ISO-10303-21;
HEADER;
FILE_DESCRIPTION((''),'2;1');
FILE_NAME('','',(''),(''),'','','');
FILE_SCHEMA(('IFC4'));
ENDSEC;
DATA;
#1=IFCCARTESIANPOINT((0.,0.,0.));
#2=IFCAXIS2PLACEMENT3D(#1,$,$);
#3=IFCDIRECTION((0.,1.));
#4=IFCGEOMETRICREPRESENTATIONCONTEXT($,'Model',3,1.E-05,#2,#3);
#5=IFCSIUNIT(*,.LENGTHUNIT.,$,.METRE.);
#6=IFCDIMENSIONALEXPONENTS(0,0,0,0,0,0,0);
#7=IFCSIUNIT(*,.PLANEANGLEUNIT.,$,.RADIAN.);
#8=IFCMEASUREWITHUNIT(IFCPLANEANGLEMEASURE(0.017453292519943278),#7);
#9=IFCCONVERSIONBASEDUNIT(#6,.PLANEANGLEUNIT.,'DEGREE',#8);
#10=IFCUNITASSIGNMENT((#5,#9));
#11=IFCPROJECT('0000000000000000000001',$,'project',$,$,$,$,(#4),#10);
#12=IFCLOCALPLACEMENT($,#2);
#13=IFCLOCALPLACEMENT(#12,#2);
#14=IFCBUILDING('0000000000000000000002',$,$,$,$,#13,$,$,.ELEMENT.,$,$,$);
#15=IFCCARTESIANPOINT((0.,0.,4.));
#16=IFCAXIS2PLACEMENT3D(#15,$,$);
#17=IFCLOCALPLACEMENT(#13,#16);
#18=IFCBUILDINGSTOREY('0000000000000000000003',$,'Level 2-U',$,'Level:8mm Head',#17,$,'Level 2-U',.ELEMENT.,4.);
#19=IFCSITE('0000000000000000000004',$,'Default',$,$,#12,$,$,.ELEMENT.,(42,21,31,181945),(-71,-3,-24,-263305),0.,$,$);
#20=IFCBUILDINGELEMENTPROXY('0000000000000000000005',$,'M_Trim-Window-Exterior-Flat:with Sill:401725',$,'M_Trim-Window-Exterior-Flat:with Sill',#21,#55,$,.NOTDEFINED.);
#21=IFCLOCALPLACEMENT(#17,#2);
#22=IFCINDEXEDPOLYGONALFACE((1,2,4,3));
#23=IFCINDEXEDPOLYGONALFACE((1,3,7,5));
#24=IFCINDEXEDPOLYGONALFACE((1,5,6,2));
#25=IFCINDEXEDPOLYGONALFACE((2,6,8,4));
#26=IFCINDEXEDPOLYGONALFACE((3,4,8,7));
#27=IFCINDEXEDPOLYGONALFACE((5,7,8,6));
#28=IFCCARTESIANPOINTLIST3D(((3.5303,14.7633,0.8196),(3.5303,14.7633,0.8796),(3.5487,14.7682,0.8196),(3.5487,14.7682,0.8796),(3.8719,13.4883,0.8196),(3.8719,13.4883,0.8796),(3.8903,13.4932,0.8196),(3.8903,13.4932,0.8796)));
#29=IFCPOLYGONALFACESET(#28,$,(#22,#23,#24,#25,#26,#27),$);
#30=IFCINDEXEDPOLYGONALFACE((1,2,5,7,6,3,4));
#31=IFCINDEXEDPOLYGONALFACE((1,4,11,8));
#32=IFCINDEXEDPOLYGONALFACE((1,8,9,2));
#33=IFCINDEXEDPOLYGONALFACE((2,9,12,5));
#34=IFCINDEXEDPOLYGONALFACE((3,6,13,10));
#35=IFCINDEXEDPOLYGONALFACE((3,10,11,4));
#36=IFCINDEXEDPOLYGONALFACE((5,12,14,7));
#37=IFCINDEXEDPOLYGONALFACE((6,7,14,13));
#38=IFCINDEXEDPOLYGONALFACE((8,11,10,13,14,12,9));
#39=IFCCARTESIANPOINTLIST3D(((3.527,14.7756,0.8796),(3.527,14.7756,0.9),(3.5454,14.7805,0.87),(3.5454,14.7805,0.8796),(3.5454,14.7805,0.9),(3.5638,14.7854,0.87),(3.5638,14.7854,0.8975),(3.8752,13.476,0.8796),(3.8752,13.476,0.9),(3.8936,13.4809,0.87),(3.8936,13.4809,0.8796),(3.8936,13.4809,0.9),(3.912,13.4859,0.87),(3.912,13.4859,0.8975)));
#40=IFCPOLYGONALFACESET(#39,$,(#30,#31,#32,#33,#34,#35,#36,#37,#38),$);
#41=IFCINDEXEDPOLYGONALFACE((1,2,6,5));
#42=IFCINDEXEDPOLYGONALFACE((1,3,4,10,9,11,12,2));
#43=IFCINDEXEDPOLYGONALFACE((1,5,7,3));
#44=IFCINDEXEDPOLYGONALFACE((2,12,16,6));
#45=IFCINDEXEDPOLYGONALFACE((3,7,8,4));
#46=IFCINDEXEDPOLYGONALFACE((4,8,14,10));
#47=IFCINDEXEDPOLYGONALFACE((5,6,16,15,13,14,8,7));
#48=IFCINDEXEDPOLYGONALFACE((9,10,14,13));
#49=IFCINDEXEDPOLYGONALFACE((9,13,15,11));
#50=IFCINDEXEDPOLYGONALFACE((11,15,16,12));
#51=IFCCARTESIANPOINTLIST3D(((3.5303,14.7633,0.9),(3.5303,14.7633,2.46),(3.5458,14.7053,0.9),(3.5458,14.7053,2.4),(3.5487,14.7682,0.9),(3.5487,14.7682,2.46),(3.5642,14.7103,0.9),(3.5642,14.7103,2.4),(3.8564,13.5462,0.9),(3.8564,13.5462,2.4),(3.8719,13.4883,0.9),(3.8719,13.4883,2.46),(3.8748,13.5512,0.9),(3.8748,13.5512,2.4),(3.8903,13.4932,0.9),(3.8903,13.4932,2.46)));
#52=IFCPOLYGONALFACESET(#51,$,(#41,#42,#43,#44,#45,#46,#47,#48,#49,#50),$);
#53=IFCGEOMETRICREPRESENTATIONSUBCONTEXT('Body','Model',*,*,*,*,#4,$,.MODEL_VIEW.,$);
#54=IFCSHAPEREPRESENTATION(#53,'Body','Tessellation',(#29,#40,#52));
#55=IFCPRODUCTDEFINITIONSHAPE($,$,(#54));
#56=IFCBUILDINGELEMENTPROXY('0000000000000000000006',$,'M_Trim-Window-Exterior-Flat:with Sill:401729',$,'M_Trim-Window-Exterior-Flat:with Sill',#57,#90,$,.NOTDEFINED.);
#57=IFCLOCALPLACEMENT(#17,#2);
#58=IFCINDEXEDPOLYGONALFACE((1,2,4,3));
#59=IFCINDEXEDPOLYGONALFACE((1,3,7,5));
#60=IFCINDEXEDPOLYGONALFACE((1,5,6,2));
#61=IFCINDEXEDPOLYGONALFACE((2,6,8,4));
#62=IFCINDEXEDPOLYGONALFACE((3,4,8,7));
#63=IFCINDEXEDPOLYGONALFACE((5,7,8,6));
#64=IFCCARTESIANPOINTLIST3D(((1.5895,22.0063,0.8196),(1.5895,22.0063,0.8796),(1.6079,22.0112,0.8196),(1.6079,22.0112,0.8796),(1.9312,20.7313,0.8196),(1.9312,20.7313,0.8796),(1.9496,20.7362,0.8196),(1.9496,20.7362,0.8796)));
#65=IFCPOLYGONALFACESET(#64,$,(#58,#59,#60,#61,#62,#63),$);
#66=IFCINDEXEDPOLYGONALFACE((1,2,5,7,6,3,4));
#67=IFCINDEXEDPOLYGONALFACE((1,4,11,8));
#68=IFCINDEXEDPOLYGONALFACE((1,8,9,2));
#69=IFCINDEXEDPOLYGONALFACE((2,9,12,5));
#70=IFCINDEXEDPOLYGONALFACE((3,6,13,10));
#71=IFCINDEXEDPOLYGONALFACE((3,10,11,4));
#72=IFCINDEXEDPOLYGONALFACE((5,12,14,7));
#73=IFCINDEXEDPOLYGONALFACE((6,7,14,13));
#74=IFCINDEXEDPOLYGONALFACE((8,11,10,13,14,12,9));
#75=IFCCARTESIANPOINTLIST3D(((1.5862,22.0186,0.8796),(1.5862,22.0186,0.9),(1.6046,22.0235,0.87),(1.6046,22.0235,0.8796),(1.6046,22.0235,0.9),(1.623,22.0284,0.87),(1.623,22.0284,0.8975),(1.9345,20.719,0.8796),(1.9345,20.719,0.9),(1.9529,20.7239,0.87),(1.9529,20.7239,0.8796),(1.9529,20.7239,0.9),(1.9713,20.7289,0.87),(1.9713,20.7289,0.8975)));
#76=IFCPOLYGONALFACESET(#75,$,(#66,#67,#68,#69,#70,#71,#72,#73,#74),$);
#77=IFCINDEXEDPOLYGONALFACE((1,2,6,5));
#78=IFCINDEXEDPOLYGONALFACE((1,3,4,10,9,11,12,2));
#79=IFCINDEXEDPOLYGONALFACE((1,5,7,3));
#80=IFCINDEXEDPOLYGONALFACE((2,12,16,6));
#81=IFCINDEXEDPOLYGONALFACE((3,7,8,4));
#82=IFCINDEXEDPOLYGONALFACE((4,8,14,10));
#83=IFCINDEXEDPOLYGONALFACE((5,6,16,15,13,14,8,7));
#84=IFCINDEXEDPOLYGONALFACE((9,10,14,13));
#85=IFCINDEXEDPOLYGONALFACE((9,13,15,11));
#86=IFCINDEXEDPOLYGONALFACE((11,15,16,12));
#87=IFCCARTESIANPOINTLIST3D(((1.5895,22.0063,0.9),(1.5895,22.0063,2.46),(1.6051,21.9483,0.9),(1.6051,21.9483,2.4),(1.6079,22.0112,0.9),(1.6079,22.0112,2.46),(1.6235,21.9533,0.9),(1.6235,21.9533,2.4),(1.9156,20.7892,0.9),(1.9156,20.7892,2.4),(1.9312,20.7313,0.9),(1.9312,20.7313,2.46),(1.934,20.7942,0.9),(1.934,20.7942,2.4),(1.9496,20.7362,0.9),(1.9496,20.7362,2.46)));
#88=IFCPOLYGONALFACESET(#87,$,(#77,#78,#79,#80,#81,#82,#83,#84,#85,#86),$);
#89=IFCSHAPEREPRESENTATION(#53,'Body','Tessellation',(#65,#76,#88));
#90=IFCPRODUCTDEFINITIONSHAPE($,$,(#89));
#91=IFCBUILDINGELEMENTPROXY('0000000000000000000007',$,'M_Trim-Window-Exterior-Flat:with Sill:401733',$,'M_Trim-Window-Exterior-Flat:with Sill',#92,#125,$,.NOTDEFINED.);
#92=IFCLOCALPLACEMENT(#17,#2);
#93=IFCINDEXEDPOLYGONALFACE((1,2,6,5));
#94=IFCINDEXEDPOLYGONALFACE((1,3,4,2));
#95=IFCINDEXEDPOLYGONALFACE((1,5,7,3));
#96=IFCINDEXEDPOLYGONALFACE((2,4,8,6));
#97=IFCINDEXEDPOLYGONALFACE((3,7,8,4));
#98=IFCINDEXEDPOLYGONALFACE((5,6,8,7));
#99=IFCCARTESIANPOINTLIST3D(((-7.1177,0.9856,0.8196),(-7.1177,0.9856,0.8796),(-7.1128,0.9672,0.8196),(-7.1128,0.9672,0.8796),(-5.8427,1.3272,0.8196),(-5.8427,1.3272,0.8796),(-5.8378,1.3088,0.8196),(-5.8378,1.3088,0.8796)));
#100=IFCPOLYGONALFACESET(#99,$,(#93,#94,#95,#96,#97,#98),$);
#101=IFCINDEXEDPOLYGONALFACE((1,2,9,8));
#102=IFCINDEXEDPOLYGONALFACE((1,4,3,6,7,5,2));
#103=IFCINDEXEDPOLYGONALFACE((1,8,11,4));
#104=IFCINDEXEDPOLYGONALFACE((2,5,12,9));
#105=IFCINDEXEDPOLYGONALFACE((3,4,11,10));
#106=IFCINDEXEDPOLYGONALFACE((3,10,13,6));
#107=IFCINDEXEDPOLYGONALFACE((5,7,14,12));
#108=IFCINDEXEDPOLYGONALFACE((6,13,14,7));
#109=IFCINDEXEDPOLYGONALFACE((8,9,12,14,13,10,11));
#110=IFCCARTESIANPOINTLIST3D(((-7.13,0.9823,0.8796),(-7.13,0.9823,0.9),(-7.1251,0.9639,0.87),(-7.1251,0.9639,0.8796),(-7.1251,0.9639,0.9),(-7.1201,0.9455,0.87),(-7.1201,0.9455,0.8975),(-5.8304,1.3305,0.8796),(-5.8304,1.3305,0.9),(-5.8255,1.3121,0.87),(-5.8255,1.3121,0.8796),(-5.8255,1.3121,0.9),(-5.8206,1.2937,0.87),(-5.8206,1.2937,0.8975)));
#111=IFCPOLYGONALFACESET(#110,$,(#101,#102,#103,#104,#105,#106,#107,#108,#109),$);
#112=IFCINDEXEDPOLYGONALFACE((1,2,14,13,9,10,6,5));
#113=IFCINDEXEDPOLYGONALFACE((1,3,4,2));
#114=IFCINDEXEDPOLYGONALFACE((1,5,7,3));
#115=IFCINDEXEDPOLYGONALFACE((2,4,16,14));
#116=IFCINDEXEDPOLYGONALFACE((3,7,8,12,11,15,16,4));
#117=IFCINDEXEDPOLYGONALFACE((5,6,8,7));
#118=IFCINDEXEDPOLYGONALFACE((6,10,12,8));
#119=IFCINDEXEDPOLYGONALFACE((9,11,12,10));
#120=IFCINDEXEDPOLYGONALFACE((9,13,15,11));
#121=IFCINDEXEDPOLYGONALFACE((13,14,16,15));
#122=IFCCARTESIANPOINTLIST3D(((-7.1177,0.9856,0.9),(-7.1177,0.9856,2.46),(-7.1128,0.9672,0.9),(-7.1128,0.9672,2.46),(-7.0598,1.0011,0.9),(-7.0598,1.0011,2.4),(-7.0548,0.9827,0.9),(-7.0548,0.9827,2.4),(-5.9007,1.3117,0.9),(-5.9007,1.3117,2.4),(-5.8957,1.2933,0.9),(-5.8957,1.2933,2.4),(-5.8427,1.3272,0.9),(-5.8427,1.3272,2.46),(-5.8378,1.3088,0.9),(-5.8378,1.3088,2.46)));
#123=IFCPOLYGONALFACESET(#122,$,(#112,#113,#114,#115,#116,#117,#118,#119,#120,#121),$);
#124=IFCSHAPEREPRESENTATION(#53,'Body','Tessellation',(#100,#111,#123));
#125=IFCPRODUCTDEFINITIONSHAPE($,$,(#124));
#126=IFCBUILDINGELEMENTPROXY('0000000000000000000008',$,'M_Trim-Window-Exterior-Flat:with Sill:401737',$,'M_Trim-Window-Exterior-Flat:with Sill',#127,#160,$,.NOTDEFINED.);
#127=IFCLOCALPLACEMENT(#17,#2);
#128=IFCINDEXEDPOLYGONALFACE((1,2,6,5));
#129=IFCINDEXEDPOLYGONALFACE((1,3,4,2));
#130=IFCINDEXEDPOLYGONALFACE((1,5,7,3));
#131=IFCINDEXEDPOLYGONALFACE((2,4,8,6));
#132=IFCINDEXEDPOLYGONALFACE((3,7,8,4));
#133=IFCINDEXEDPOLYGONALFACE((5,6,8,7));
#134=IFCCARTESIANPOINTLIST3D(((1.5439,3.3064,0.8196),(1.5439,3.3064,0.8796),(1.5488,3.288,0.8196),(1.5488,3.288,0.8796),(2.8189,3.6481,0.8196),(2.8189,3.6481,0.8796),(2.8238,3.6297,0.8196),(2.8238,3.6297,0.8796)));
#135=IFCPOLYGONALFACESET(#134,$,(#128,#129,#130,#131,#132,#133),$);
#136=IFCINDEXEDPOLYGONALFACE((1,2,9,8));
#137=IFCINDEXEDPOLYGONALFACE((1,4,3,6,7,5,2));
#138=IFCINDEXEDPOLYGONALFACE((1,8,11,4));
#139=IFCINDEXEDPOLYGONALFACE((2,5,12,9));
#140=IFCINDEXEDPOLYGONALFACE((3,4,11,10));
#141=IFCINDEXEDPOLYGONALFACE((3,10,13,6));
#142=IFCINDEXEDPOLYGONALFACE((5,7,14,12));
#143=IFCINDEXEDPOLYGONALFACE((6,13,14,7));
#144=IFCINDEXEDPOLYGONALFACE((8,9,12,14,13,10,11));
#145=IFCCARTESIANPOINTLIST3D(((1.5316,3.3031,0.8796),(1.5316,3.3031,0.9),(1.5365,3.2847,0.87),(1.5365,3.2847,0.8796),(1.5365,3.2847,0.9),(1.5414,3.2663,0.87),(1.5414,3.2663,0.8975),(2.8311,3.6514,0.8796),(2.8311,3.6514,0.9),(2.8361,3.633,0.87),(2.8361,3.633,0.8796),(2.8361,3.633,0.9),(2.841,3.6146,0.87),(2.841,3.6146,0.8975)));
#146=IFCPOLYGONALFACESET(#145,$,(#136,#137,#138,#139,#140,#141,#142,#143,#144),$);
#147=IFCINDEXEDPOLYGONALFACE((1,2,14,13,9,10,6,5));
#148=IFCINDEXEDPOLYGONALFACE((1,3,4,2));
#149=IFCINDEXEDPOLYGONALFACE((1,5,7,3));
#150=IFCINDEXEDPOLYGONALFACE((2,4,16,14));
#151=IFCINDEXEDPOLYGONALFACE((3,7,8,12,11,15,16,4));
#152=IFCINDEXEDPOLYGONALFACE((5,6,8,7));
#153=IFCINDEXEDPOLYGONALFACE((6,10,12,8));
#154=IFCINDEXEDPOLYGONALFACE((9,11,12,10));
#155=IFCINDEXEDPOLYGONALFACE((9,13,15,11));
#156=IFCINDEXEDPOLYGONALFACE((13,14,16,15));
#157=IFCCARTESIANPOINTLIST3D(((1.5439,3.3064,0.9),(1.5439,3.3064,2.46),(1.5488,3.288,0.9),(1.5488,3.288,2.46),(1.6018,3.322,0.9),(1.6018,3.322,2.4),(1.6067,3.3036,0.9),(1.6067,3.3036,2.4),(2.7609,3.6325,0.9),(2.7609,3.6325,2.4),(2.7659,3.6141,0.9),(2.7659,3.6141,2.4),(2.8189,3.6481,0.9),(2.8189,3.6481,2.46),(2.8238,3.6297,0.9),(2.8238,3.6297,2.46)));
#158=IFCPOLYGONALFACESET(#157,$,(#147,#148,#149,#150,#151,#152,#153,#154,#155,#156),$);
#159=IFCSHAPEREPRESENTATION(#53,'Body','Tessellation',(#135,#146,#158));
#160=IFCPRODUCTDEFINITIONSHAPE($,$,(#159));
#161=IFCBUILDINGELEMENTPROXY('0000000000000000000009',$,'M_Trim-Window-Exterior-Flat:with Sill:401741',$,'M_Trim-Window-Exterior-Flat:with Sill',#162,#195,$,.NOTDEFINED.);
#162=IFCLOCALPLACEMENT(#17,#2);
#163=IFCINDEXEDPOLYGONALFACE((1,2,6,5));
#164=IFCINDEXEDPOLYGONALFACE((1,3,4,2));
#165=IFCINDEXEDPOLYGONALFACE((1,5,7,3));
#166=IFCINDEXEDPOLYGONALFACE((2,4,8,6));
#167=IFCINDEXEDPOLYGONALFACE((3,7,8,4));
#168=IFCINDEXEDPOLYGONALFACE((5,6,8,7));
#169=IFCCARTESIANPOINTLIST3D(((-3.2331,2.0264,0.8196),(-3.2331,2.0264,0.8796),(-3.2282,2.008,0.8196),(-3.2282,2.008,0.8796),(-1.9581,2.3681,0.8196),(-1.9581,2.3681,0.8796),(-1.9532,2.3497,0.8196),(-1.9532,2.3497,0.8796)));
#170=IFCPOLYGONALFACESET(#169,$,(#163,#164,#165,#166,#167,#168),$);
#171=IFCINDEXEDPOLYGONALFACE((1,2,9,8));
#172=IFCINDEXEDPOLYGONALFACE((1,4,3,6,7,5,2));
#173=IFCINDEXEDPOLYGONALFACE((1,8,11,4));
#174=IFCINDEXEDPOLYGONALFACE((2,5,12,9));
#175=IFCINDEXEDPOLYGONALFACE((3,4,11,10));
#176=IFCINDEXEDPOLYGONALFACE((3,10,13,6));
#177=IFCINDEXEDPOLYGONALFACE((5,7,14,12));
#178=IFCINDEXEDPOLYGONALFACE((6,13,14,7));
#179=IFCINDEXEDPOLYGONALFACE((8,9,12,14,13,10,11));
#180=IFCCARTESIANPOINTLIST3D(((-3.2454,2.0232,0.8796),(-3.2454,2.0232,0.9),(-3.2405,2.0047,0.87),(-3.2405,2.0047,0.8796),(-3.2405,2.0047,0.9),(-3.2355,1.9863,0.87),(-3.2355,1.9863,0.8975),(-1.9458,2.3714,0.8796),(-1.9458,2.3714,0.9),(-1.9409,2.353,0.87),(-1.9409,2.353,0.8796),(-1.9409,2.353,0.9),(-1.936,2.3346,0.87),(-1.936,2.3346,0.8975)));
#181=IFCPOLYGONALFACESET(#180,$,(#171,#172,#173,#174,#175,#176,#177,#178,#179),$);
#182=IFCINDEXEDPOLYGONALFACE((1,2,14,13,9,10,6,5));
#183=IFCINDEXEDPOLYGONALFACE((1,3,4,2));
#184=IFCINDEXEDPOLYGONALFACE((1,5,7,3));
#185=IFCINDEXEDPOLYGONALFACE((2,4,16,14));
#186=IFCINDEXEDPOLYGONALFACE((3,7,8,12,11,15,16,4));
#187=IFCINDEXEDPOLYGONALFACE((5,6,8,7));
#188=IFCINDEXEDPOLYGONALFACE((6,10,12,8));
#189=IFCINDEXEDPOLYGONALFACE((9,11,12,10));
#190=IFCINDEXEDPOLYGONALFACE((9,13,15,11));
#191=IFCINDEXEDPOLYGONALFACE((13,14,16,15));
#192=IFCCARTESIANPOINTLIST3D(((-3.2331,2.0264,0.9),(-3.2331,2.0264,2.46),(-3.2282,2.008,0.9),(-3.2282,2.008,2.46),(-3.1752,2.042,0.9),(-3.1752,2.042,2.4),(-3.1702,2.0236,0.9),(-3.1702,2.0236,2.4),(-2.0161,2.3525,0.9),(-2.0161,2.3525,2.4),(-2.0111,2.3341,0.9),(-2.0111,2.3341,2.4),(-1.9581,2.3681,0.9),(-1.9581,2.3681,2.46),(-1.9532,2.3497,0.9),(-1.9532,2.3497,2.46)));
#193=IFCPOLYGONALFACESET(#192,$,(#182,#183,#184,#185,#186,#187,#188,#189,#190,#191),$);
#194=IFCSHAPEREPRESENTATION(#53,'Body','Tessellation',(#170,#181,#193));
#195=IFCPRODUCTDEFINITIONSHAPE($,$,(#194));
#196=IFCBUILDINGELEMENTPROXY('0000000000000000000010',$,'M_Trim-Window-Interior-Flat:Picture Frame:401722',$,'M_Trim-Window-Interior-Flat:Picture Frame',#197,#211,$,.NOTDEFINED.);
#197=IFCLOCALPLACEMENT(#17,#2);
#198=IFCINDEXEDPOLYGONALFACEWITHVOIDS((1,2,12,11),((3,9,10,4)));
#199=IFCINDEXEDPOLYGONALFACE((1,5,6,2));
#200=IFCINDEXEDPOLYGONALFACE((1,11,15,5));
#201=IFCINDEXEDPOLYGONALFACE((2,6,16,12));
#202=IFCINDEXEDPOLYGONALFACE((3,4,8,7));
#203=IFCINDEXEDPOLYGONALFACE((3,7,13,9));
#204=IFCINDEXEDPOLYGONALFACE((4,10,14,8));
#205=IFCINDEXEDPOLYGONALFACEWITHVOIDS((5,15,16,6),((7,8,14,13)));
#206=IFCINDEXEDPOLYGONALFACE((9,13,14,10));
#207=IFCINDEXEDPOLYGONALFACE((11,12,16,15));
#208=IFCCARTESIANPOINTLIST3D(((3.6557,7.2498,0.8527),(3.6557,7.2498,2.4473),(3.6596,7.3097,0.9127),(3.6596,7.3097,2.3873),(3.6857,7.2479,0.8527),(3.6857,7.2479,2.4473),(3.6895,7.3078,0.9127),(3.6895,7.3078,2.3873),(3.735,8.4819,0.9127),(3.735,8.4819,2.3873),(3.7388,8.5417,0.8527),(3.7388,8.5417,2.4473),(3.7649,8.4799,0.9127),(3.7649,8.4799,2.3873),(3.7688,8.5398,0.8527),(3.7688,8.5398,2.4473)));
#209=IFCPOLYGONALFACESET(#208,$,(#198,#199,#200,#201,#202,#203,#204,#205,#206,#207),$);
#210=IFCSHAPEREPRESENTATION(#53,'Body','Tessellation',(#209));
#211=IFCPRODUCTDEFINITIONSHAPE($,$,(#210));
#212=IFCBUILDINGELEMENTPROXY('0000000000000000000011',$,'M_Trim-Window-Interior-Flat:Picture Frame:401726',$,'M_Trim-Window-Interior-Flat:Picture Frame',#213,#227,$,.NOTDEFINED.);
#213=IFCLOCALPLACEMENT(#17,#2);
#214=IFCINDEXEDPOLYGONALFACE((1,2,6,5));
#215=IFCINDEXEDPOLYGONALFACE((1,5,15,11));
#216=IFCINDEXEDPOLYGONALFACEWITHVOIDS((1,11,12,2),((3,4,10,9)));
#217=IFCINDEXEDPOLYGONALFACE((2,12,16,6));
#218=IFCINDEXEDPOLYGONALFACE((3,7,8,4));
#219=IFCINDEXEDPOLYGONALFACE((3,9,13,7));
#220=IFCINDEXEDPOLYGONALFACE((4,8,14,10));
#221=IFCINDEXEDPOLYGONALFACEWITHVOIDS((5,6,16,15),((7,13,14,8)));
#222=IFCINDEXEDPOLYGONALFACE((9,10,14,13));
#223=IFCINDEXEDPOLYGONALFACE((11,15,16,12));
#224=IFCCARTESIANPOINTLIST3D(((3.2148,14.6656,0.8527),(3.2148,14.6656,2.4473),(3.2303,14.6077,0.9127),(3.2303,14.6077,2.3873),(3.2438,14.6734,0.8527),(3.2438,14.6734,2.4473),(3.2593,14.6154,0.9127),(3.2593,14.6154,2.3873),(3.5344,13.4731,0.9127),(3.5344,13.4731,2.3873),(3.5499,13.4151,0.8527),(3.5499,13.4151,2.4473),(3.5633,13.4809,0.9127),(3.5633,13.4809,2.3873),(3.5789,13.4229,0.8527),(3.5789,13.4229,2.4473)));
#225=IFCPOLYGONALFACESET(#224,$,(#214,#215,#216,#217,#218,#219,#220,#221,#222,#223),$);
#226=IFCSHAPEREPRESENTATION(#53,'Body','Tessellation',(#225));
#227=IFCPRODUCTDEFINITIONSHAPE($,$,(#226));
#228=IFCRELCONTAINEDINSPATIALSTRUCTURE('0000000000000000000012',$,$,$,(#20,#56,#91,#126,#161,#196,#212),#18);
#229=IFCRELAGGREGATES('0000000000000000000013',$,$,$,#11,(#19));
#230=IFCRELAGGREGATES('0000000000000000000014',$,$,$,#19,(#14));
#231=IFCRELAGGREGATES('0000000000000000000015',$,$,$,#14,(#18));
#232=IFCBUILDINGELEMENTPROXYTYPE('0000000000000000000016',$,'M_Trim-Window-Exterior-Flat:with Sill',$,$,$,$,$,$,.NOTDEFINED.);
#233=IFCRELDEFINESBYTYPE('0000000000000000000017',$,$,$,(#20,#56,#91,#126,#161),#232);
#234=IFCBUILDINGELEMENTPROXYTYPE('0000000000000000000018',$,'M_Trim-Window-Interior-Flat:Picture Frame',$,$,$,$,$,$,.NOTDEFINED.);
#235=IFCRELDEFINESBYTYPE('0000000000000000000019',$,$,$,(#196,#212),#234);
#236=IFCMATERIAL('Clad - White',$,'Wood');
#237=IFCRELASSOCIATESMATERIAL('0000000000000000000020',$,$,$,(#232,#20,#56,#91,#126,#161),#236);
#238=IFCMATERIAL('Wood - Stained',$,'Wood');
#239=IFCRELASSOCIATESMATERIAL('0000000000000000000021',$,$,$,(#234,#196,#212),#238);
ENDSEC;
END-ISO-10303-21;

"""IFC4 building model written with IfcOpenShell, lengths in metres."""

from ifc_helpers import new_model, entity, si_unit, converted_unit, direction, frame, frame_2d, origin, place, context, subcontext, project, spatial, polyline, rectangle, outline, extrude, source, transform, mapped, material, type_object, type_shapes, element, save


model = new_model("IFC4")

# Units and contexts
model_context = context("Model", 3, precision=1e-05, world=origin(), true_north=direction((0.0, 1.0)))
body_context = subcontext(model_context, "Body", "Model", "MODEL_VIEW")
ifc_project = project(units=[si_unit("LENGTHUNIT", "METRE"), converted_unit("PLANEANGLEUNIT", "DEGREE", entity("IfcPlaneAngleMeasure", 0.017453292519943278), si_unit("PLANEANGLEUNIT", "RADIAN"), dimensions=[0, 0, 0, 0, 0, 0, 0])], contexts=[model_context])

# Site, building, storey
site_placement = place(None, origin())
site = spatial("IfcSite", under=ifc_project, at=site_placement, Name="Default", CompositionType="ELEMENT", RefLatitude=(42, 21, 31, 181945), RefLongitude=(-71, -3, -24, -263305), RefElevation=0.0)
building_placement = place(site_placement, origin())
building = spatial("IfcBuilding", under=site, at=building_placement, CompositionType="ELEMENT")
storey_placement = place(building_placement, frame((0.0, 0.0, 4.0)))
storey = spatial("IfcBuildingStorey", under=building, at=storey_placement, Name="Level 2-U", ObjectType="Level:8mm Head", LongName="Level 2-U", CompositionType="ELEMENT", Elevation=4.0)

# Building element proxies
ifc_material_1 = material(Name="Clad - White", Category="Wood")
ifc_material_2 = material(Name="Wood - Stained", Category="Wood")
building_element_proxy_type_1 = type_object("IfcBuildingElementProxyType", Name="M_Trim-Window-Exterior-Flat:with Sill", PredefinedType="NOTDEFINED", material=ifc_material_1)
shared_shape_1 = source(origin(), body_context, "Body", "SweptSolid", [
    extrude(rectangle(XDim=1.32, YDim=0.06, at=frame_2d((0.0, 0.0), x_axis=(1.0, 0.0))), frame((0.0, -1.5504, 0.0), z_axis=(0.0, 0.0, 1.0), x_axis=(-1.0, 0.0, 0.0)), (0.0, 0.0, 1.0), 0.019),
    extrude(outline(polyline([(-0.019, -0.0152), (0.0, -0.0152), (0.0, -0.0057), (0.019, -0.0057), (0.019, 0.0148), (0.0, 0.0148), (-0.019, 0.0123), (-0.019, -0.0152)])), frame((-0.6727, -1.5148, 0.019), z_axis=(1.0, 0.0, 0.0), x_axis=(0.0, 0.0, -1.0)), (0.0, 0.0, 1.0), 1.3454),
    extrude(outline(polyline([(-0.795, -0.66), (0.765, -0.66), (0.765, -0.6), (-0.735, -0.6), (-0.735, 0.6), (0.765, 0.6), (0.765, 0.66), (-0.795, 0.66), (-0.795, -0.66)])), frame((0.0, -0.735, 0.0), z_axis=(0.0, 0.0, 1.0), x_axis=(0.0, -1.0, 0.0)), (0.0, 0.0, 1.0), 0.019),
])
type_shapes(building_element_proxy_type_1, [shared_shape_1])
for number, where, z_axis, x_axis, name in (
    (1, (3.7011, 14.1258, 2.4), (0.965926, 0.258819, 0.0), (-0.258819, 0.965926, 0.0), "M_Trim-Window-Exterior-Flat:with Sill:401725"),
    (2, (1.7603, 21.3688, 2.4), (0.965926, 0.258819, 0.0), (-0.258819, 0.965926, 0.0), "M_Trim-Window-Exterior-Flat:with Sill:401729"),
    (3, (-6.4802, 1.1564, 2.4), (0.258819, -0.965926, 0.0), (0.965926, 0.258819, 0.0), "M_Trim-Window-Exterior-Flat:with Sill:401733"),
    (4, (2.1814, 3.4772, 2.4), (0.258819, -0.965926, 0.0), (0.965926, 0.258819, 0.0), "M_Trim-Window-Exterior-Flat:with Sill:401737"),
    (5, (-2.5956, 2.1973, 2.4), (0.258819, -0.965926, 0.0), (0.965926, 0.258819, 0.0), "M_Trim-Window-Exterior-Flat:with Sill:401741"),
):
    element("IfcBuildingElementProxy", number, at=place(storey_placement, frame(where, z_axis=z_axis, x_axis=x_axis)), inside=storey, type_object=building_element_proxy_type_1, material=ifc_material_1, Name=name, ObjectType="M_Trim-Window-Exterior-Flat:with Sill", PredefinedType="NOTDEFINED", context=body_context, shape_type="MappedRepresentation", body=[
        mapped(shared_shape_1, transform((0.0, 0.0, 0.0), scale=1.0)),
    ])
building_element_proxy_type_2 = type_object("IfcBuildingElementProxyType", Name="M_Trim-Window-Interior-Flat:Picture Frame", PredefinedType="NOTDEFINED", material=ifc_material_2)
shared_shape_2 = source(origin(), body_context, "Body", "SweptSolid", [
    extrude(outline(polyline([(-0.6473, -0.7973), (0.6473, -0.7973), (0.6473, 0.7973), (-0.6473, 0.7973), (-0.6473, -0.7973)]), holes=[polyline([(-0.5873, -0.7373), (-0.5873, 0.7373), (0.5873, 0.7373), (0.5873, -0.7373), (-0.5873, -0.7373)])]), frame((0.0, -0.75, 0.0), z_axis=(0.0, 0.0, 1.0), x_axis=(-1.0, 0.0, 0.0)), (0.0, 0.0, 1.0), 0.03),
])
type_shapes(building_element_proxy_type_2, [shared_shape_2])
for number, where, z_axis, x_axis, name in (
    (6, (3.7272, 7.8938, 2.4), (-0.997938, 0.064186, 0.0), (-0.064186, -0.997938, 0.0), "M_Trim-Window-Interior-Flat:Picture Frame:401722"),
    (7, (3.4113, 14.0481, 2.4), (-0.965926, -0.258819, 0.0), (0.258819, -0.965926, 0.0), "M_Trim-Window-Interior-Flat:Picture Frame:401726"),
):
    element("IfcBuildingElementProxy", number, at=place(storey_placement, frame(where, z_axis=z_axis, x_axis=x_axis)), inside=storey, type_object=building_element_proxy_type_2, material=ifc_material_2, Name=name, ObjectType="M_Trim-Window-Interior-Flat:Picture Frame", PredefinedType="NOTDEFINED", context=body_context, shape_type="MappedRepresentation", body=[
        mapped(shared_shape_2, transform((0.0, 0.0, 0.0), scale=1.0)),
    ])

save(model, "model.ifc")
